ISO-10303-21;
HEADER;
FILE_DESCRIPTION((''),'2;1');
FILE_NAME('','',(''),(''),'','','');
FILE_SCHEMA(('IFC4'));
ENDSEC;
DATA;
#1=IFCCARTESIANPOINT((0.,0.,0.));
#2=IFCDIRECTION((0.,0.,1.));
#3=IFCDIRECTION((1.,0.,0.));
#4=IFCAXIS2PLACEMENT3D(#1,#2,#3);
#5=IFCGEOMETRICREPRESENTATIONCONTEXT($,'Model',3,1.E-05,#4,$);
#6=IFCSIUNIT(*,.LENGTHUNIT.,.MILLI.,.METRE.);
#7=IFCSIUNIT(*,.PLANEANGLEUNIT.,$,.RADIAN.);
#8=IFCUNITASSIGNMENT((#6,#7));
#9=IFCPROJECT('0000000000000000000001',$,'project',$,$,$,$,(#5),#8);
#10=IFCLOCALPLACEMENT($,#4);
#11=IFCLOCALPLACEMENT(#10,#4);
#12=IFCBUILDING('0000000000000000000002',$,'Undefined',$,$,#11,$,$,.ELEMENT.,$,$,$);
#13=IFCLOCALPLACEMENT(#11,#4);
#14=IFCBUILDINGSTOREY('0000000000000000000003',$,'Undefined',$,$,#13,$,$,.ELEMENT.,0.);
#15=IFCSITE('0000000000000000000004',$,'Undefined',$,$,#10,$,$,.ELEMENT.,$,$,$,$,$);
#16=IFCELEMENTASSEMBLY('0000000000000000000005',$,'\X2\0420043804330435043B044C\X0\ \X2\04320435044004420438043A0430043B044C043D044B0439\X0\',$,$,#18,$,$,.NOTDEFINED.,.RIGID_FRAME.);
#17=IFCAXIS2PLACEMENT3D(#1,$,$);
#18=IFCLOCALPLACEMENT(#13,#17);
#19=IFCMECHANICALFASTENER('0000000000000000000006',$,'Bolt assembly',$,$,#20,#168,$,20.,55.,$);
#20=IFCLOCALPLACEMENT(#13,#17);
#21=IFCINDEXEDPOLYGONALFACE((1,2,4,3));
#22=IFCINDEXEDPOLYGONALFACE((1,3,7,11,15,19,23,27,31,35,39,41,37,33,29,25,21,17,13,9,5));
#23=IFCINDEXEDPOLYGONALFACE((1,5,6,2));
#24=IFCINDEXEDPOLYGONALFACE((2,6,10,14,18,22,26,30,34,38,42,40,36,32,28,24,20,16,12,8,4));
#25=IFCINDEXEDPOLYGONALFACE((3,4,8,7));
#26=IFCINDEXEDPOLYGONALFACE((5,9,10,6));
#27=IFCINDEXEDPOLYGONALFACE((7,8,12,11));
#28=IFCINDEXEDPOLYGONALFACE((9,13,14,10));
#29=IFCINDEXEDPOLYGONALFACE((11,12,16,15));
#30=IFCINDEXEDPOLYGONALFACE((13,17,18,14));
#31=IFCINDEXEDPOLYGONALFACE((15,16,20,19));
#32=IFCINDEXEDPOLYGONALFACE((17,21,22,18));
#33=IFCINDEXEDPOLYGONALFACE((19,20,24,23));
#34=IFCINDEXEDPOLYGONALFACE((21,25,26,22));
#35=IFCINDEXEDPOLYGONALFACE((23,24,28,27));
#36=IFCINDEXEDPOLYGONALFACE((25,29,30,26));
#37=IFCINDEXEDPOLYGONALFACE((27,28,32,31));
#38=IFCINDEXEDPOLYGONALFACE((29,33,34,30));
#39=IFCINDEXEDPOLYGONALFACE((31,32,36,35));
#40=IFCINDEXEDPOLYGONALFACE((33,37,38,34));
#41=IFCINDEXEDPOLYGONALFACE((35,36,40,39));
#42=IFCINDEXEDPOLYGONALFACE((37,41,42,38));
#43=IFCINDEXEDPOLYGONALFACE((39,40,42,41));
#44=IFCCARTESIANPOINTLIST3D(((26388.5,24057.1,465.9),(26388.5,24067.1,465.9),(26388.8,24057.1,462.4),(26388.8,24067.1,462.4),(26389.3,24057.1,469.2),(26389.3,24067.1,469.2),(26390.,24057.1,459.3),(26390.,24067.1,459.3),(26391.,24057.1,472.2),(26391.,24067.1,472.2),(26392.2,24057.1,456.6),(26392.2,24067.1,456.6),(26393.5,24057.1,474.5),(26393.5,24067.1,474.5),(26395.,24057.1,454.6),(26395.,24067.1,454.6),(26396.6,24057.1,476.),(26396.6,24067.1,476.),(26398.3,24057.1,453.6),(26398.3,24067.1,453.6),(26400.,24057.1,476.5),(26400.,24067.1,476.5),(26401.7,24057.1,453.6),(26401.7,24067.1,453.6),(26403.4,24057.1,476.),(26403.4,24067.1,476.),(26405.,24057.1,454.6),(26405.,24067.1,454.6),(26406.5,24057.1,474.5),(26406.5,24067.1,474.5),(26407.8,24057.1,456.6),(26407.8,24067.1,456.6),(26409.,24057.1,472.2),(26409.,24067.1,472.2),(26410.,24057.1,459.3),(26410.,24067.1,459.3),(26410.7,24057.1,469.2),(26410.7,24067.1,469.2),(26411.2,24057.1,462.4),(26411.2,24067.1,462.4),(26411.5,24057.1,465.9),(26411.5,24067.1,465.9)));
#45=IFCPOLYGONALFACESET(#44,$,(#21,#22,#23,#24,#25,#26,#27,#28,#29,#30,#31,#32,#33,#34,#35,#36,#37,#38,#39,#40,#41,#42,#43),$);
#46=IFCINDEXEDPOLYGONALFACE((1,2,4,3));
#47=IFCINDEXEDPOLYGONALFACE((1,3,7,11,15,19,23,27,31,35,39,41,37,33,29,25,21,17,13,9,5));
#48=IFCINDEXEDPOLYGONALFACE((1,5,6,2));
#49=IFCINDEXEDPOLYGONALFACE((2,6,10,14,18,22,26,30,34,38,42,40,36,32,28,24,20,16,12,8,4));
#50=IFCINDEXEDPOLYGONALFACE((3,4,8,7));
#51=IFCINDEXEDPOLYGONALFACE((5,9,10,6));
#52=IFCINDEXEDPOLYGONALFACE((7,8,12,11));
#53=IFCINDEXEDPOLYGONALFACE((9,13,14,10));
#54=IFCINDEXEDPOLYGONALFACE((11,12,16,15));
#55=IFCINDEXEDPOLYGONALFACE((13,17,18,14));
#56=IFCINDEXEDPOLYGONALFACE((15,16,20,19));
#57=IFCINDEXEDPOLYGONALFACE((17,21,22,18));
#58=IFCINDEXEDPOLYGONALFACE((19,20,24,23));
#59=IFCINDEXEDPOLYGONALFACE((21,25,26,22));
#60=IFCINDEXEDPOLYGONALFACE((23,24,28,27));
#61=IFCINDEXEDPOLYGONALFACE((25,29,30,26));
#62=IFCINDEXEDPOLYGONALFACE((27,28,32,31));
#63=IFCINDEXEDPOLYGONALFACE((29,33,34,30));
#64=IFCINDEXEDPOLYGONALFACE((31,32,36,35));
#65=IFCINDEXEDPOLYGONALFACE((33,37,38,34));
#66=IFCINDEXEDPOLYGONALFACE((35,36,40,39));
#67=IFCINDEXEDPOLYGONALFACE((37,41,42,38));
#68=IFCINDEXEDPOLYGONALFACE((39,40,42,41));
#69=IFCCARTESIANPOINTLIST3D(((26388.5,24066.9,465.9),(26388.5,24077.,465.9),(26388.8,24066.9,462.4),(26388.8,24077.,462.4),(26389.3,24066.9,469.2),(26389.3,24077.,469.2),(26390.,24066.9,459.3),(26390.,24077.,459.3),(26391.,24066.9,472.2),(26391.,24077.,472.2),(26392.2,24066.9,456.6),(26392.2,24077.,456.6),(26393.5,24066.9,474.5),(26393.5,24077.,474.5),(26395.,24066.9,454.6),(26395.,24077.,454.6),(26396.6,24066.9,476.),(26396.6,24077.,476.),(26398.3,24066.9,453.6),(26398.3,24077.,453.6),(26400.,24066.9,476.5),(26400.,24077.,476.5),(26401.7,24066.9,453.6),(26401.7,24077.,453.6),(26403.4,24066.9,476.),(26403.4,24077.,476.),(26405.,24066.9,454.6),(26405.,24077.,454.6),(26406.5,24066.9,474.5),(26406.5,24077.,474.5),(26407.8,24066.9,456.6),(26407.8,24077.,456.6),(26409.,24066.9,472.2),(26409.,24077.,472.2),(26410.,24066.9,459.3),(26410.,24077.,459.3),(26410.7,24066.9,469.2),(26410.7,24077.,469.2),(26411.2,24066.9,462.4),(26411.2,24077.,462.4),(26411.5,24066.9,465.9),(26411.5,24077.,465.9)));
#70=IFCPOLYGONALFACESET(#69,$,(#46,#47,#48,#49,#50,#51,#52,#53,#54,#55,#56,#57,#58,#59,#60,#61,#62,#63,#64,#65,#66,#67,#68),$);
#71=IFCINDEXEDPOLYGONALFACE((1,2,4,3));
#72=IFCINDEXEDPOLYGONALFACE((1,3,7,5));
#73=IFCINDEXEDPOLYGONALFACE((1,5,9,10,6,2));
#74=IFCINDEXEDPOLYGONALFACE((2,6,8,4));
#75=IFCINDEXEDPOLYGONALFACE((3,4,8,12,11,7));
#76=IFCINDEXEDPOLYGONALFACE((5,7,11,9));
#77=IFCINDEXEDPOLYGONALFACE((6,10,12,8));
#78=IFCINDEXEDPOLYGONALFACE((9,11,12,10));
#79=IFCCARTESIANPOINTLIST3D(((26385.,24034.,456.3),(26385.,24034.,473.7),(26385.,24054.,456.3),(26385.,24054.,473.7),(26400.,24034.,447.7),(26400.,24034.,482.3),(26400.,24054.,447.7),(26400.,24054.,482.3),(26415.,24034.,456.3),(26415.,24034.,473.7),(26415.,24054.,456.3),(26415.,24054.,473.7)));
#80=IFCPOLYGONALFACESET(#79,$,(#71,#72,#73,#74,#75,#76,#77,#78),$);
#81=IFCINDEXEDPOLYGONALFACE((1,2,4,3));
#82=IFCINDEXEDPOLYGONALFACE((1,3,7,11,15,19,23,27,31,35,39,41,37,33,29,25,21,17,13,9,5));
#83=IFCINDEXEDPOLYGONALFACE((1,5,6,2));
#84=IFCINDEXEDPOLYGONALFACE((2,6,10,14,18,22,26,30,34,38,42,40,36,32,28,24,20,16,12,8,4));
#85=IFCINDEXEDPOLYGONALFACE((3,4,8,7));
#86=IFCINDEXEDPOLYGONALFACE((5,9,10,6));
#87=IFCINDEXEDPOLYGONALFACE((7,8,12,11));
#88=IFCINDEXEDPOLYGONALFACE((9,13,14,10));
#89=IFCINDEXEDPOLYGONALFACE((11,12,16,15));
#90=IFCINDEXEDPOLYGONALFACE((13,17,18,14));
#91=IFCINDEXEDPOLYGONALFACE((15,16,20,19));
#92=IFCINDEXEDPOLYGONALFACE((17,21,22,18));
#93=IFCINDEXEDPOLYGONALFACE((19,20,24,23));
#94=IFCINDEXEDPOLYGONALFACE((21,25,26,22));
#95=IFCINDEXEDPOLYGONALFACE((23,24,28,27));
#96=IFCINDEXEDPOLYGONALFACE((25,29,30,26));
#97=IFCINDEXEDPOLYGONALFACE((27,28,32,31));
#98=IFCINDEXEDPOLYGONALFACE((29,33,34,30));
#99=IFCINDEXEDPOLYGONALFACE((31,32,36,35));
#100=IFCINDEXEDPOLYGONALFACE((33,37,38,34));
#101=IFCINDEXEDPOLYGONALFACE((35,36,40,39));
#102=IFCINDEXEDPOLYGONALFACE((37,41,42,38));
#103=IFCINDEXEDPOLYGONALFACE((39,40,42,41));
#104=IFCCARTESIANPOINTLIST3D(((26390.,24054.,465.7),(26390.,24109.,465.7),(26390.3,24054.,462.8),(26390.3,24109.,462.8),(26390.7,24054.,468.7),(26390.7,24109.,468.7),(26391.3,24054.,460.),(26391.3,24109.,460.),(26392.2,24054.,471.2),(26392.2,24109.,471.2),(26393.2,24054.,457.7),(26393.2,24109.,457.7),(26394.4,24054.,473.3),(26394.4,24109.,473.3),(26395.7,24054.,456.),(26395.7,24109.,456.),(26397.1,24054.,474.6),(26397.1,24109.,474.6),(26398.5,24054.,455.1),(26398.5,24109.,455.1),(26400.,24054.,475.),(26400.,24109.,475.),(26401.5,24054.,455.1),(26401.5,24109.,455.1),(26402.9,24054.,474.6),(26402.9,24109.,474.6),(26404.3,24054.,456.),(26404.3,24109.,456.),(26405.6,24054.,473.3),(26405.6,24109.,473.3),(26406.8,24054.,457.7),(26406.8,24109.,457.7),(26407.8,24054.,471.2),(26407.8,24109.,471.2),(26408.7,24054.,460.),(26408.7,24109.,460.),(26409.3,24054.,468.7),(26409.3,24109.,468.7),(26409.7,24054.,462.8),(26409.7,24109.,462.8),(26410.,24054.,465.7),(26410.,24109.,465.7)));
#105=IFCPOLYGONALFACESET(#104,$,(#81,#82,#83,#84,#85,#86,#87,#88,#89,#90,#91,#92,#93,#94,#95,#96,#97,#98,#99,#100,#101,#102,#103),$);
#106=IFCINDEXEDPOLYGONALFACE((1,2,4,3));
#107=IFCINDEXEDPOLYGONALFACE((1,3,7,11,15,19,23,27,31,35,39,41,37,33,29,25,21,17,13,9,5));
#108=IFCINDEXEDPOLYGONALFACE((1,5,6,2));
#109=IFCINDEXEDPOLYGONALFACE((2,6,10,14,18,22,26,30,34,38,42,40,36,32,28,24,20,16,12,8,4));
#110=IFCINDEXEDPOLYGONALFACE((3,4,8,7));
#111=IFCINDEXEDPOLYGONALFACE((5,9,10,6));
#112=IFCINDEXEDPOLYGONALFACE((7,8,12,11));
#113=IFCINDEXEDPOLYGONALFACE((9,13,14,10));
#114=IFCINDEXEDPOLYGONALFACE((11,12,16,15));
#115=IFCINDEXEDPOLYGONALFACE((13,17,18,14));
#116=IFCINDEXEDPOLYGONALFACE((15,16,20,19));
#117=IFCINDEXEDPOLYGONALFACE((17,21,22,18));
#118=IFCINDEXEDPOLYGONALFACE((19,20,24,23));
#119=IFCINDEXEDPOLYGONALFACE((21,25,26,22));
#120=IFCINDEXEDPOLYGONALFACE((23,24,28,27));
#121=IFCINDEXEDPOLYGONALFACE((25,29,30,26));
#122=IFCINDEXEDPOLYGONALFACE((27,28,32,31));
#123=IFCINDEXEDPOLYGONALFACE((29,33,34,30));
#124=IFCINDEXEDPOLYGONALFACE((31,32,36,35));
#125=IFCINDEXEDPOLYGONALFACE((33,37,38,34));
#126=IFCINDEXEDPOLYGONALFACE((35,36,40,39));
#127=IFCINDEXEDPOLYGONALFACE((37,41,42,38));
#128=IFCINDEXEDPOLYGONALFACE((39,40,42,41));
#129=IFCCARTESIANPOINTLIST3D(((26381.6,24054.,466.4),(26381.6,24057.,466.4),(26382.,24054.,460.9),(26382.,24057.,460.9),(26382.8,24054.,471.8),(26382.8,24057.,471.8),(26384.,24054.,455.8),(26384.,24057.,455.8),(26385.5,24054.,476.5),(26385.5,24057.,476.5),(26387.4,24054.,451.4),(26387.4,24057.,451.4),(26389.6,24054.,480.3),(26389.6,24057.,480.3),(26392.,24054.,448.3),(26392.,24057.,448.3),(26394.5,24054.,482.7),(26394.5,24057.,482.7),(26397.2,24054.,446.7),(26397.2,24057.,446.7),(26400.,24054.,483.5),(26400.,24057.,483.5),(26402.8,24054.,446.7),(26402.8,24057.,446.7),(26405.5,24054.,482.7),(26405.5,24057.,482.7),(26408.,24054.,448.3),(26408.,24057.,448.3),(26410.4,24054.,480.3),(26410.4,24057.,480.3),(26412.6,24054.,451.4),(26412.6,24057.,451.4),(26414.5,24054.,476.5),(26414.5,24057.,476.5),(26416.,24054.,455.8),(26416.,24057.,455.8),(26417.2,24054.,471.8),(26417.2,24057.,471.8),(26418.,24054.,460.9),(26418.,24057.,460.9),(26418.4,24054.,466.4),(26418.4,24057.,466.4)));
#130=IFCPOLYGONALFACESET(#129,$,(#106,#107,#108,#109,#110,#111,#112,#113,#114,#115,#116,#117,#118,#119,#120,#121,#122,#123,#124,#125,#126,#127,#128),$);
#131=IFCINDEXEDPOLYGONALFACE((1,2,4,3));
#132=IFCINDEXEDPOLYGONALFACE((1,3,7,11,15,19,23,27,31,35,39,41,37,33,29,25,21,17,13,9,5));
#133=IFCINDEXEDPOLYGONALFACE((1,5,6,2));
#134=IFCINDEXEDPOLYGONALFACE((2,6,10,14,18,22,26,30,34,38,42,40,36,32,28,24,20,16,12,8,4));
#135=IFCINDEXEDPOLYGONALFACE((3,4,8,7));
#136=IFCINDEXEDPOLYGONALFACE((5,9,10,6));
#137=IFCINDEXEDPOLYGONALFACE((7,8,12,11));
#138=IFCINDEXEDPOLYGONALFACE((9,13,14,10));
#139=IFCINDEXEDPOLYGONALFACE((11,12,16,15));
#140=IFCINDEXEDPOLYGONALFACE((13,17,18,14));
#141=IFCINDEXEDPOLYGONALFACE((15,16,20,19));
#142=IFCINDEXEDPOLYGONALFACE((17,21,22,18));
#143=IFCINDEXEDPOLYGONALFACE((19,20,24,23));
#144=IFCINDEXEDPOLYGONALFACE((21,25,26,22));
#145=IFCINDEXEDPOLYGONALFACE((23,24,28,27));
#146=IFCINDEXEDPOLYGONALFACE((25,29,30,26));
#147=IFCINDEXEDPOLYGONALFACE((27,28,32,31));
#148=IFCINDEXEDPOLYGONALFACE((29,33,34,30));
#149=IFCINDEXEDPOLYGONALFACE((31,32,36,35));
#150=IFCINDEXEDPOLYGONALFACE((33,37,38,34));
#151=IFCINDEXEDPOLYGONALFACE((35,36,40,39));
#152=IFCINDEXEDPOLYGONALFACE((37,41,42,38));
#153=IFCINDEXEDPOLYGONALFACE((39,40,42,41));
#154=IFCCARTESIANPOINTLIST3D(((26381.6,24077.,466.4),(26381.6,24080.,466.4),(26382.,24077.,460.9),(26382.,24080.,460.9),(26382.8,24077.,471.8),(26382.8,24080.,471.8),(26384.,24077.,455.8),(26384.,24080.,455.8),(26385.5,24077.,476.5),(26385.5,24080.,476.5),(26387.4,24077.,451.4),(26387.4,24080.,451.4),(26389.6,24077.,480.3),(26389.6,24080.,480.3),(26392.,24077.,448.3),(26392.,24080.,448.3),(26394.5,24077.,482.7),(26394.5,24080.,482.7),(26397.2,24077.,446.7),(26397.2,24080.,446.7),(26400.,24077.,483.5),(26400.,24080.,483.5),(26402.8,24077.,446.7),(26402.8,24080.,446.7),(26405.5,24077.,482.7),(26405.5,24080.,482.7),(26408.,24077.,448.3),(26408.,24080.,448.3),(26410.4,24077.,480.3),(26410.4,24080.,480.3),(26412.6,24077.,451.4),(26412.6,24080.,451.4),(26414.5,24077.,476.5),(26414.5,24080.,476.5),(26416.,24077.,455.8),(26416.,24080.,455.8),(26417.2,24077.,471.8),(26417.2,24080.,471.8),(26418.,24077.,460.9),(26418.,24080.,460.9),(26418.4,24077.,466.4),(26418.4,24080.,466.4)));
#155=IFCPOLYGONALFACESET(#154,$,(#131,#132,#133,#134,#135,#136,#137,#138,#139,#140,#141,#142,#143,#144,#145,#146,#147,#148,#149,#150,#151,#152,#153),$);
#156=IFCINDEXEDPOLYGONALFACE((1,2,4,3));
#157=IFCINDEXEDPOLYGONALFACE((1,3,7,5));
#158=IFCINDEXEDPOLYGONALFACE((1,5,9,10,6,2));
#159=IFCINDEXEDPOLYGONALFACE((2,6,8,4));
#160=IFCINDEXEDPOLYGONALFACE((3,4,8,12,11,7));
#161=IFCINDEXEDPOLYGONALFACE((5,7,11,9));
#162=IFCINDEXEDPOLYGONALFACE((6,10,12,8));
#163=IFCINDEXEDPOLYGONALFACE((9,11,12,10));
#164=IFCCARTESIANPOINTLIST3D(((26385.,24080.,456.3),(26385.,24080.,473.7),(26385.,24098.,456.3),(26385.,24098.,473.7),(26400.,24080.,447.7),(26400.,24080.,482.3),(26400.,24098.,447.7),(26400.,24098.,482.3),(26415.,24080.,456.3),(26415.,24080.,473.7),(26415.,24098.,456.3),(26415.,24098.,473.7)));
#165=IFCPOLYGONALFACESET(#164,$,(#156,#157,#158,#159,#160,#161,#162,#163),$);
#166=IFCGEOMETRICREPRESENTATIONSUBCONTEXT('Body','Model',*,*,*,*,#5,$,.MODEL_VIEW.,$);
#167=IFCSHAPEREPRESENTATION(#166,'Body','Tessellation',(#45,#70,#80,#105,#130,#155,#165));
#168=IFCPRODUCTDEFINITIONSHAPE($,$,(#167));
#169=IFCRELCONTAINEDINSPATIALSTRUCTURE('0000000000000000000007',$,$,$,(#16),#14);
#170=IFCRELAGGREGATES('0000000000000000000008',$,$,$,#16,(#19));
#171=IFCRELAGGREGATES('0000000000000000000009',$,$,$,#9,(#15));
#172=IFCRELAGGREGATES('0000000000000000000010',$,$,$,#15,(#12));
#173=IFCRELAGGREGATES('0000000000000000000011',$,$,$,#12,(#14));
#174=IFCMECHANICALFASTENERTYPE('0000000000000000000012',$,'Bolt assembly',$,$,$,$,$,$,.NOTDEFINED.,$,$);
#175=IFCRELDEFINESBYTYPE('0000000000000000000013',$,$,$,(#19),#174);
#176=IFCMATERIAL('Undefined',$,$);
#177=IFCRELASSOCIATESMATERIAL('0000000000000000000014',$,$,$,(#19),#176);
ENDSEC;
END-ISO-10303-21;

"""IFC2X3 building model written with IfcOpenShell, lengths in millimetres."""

from ifc_helpers import new_model, si_unit, frame, origin_with_axes, origin_2d_with_axis, place, context, subcontext, project, spatial, polyline, circle, outline, extrude, source, transform, mapped, material, type_object, element, aggregate, save


model = new_model("IFC2X3")

# Units and contexts
model_context = context("Model", 3, precision=1e-05, world=origin_with_axes())
body_context = subcontext(model_context, "Body", "Model", "MODEL_VIEW")
ifc_project = project(units=[si_unit("LENGTHUNIT", "METRE", prefix="MILLI"), si_unit("PLANEANGLEUNIT", "RADIAN")], contexts=[model_context])

# Site, building, storey
site_placement = place(None, origin_with_axes())
site = spatial("IfcSite", under=ifc_project, at=site_placement, Name="Undefined", CompositionType="ELEMENT")
building_placement = place(site_placement, origin_with_axes())
building = spatial("IfcBuilding", under=site, at=building_placement, Name="Undefined", CompositionType="ELEMENT")
storey_placement = place(building_placement, origin_with_axes())
storey = spatial("IfcBuildingStorey", under=building, at=storey_placement, Name="Undefined", CompositionType="ELEMENT", Elevation=0.0)

# Element assembly
assembly_1_placement = place(storey_placement, origin_with_axes())
assembly_1 = element("IfcElementAssembly", 1, at=assembly_1_placement, inside=storey, Name="Ригель вертикальный", AssemblyPlace="NOTDEFINED", PredefinedType="RIGID_FRAME")

# Mechanical fastener
ifc_material_1 = material(Name="Undefined")
mechanical_fastener_type = type_object("IfcMechanicalFastenerType", Name="Bolt assembly")
shared_shape = source(origin_with_axes(), body_context, "Body", "SweptSolid", [
    extrude(circle(Radius=11.5, at=origin_2d_with_axis()), frame((0.0, 0.1, 0.0), z_axis=(0.0, 1.0, 0.0), x_axis=(1.0, 0.0, 0.0)), (0.0, 0.0, 1.0), 10.0),
    extrude(circle(Radius=11.5, at=origin_2d_with_axis()), frame((0.0, 9.9, 0.0), z_axis=(0.0, 1.0, 0.0), x_axis=(1.0, 0.0, 0.0)), (0.0, 0.0, 1.0), 10.1),
    extrude(outline(polyline([(17.3, 0.0), (8.7, 15.0), (-8.7, 15.0), (-17.3, 0.0), (-8.7, -15.0), (8.7, -15.0), (17.3, 0.0)])), frame((0.0, -23.0, 0.0), z_axis=(0.0, 1.0, 0.0), x_axis=(1.0, 0.0, 0.0)), (0.0, 0.0, 1.0), 20.0),
    extrude(circle(Radius=10.0, at=origin_2d_with_axis()), frame((0.0, -3.0, 0.0), z_axis=(0.0, 1.0, 0.0), x_axis=(1.0, 0.0, 0.0)), (0.0, 0.0, 1.0), 55.0),
    extrude(circle(Radius=18.5, at=origin_2d_with_axis()), frame((0.0, -3.0, 0.0), z_axis=(0.0, 1.0, 0.0), x_axis=(1.0, 0.0, 0.0)), (0.0, 0.0, 1.0), 3.0),
    extrude(circle(Radius=18.5, at=origin_2d_with_axis()), frame((0.0, 20.0, 0.0), z_axis=(0.0, 1.0, 0.0), x_axis=(1.0, 0.0, 0.0)), (0.0, 0.0, 1.0), 3.0),
    extrude(outline(polyline([(17.3, 0.0), (8.7, 15.0), (-8.7, 15.0), (-17.3, 0.0), (-8.7, -15.0), (8.7, -15.0), (17.3, 0.0)])), frame((0.0, 23.0, 0.0), z_axis=(0.0, 1.0, 0.0), x_axis=(1.0, 0.0, 0.0)), (0.0, 0.0, 1.0), 18.0),
])
mechanical_fastener_1_placement = place(assembly_1_placement, frame((26400.0, 24057.0, 465.0), z_axis=(-1.0, 0.0, 0.0), x_axis=(0.0, 0.0, 1.0)))
mechanical_fastener_1 = element("IfcMechanicalFastener", 2, at=mechanical_fastener_1_placement, type_object=mechanical_fastener_type, material=ifc_material_1, Name="Bolt assembly", NominalDiameter=20.0, NominalLength=55.0, context=body_context, shape_type="MappedRepresentation", body=[
    mapped(shared_shape, transform((0.0, 0.0, 0.0))),
])
aggregate(assembly_1, [mechanical_fastener_1])

save(model, "model.ifc")
